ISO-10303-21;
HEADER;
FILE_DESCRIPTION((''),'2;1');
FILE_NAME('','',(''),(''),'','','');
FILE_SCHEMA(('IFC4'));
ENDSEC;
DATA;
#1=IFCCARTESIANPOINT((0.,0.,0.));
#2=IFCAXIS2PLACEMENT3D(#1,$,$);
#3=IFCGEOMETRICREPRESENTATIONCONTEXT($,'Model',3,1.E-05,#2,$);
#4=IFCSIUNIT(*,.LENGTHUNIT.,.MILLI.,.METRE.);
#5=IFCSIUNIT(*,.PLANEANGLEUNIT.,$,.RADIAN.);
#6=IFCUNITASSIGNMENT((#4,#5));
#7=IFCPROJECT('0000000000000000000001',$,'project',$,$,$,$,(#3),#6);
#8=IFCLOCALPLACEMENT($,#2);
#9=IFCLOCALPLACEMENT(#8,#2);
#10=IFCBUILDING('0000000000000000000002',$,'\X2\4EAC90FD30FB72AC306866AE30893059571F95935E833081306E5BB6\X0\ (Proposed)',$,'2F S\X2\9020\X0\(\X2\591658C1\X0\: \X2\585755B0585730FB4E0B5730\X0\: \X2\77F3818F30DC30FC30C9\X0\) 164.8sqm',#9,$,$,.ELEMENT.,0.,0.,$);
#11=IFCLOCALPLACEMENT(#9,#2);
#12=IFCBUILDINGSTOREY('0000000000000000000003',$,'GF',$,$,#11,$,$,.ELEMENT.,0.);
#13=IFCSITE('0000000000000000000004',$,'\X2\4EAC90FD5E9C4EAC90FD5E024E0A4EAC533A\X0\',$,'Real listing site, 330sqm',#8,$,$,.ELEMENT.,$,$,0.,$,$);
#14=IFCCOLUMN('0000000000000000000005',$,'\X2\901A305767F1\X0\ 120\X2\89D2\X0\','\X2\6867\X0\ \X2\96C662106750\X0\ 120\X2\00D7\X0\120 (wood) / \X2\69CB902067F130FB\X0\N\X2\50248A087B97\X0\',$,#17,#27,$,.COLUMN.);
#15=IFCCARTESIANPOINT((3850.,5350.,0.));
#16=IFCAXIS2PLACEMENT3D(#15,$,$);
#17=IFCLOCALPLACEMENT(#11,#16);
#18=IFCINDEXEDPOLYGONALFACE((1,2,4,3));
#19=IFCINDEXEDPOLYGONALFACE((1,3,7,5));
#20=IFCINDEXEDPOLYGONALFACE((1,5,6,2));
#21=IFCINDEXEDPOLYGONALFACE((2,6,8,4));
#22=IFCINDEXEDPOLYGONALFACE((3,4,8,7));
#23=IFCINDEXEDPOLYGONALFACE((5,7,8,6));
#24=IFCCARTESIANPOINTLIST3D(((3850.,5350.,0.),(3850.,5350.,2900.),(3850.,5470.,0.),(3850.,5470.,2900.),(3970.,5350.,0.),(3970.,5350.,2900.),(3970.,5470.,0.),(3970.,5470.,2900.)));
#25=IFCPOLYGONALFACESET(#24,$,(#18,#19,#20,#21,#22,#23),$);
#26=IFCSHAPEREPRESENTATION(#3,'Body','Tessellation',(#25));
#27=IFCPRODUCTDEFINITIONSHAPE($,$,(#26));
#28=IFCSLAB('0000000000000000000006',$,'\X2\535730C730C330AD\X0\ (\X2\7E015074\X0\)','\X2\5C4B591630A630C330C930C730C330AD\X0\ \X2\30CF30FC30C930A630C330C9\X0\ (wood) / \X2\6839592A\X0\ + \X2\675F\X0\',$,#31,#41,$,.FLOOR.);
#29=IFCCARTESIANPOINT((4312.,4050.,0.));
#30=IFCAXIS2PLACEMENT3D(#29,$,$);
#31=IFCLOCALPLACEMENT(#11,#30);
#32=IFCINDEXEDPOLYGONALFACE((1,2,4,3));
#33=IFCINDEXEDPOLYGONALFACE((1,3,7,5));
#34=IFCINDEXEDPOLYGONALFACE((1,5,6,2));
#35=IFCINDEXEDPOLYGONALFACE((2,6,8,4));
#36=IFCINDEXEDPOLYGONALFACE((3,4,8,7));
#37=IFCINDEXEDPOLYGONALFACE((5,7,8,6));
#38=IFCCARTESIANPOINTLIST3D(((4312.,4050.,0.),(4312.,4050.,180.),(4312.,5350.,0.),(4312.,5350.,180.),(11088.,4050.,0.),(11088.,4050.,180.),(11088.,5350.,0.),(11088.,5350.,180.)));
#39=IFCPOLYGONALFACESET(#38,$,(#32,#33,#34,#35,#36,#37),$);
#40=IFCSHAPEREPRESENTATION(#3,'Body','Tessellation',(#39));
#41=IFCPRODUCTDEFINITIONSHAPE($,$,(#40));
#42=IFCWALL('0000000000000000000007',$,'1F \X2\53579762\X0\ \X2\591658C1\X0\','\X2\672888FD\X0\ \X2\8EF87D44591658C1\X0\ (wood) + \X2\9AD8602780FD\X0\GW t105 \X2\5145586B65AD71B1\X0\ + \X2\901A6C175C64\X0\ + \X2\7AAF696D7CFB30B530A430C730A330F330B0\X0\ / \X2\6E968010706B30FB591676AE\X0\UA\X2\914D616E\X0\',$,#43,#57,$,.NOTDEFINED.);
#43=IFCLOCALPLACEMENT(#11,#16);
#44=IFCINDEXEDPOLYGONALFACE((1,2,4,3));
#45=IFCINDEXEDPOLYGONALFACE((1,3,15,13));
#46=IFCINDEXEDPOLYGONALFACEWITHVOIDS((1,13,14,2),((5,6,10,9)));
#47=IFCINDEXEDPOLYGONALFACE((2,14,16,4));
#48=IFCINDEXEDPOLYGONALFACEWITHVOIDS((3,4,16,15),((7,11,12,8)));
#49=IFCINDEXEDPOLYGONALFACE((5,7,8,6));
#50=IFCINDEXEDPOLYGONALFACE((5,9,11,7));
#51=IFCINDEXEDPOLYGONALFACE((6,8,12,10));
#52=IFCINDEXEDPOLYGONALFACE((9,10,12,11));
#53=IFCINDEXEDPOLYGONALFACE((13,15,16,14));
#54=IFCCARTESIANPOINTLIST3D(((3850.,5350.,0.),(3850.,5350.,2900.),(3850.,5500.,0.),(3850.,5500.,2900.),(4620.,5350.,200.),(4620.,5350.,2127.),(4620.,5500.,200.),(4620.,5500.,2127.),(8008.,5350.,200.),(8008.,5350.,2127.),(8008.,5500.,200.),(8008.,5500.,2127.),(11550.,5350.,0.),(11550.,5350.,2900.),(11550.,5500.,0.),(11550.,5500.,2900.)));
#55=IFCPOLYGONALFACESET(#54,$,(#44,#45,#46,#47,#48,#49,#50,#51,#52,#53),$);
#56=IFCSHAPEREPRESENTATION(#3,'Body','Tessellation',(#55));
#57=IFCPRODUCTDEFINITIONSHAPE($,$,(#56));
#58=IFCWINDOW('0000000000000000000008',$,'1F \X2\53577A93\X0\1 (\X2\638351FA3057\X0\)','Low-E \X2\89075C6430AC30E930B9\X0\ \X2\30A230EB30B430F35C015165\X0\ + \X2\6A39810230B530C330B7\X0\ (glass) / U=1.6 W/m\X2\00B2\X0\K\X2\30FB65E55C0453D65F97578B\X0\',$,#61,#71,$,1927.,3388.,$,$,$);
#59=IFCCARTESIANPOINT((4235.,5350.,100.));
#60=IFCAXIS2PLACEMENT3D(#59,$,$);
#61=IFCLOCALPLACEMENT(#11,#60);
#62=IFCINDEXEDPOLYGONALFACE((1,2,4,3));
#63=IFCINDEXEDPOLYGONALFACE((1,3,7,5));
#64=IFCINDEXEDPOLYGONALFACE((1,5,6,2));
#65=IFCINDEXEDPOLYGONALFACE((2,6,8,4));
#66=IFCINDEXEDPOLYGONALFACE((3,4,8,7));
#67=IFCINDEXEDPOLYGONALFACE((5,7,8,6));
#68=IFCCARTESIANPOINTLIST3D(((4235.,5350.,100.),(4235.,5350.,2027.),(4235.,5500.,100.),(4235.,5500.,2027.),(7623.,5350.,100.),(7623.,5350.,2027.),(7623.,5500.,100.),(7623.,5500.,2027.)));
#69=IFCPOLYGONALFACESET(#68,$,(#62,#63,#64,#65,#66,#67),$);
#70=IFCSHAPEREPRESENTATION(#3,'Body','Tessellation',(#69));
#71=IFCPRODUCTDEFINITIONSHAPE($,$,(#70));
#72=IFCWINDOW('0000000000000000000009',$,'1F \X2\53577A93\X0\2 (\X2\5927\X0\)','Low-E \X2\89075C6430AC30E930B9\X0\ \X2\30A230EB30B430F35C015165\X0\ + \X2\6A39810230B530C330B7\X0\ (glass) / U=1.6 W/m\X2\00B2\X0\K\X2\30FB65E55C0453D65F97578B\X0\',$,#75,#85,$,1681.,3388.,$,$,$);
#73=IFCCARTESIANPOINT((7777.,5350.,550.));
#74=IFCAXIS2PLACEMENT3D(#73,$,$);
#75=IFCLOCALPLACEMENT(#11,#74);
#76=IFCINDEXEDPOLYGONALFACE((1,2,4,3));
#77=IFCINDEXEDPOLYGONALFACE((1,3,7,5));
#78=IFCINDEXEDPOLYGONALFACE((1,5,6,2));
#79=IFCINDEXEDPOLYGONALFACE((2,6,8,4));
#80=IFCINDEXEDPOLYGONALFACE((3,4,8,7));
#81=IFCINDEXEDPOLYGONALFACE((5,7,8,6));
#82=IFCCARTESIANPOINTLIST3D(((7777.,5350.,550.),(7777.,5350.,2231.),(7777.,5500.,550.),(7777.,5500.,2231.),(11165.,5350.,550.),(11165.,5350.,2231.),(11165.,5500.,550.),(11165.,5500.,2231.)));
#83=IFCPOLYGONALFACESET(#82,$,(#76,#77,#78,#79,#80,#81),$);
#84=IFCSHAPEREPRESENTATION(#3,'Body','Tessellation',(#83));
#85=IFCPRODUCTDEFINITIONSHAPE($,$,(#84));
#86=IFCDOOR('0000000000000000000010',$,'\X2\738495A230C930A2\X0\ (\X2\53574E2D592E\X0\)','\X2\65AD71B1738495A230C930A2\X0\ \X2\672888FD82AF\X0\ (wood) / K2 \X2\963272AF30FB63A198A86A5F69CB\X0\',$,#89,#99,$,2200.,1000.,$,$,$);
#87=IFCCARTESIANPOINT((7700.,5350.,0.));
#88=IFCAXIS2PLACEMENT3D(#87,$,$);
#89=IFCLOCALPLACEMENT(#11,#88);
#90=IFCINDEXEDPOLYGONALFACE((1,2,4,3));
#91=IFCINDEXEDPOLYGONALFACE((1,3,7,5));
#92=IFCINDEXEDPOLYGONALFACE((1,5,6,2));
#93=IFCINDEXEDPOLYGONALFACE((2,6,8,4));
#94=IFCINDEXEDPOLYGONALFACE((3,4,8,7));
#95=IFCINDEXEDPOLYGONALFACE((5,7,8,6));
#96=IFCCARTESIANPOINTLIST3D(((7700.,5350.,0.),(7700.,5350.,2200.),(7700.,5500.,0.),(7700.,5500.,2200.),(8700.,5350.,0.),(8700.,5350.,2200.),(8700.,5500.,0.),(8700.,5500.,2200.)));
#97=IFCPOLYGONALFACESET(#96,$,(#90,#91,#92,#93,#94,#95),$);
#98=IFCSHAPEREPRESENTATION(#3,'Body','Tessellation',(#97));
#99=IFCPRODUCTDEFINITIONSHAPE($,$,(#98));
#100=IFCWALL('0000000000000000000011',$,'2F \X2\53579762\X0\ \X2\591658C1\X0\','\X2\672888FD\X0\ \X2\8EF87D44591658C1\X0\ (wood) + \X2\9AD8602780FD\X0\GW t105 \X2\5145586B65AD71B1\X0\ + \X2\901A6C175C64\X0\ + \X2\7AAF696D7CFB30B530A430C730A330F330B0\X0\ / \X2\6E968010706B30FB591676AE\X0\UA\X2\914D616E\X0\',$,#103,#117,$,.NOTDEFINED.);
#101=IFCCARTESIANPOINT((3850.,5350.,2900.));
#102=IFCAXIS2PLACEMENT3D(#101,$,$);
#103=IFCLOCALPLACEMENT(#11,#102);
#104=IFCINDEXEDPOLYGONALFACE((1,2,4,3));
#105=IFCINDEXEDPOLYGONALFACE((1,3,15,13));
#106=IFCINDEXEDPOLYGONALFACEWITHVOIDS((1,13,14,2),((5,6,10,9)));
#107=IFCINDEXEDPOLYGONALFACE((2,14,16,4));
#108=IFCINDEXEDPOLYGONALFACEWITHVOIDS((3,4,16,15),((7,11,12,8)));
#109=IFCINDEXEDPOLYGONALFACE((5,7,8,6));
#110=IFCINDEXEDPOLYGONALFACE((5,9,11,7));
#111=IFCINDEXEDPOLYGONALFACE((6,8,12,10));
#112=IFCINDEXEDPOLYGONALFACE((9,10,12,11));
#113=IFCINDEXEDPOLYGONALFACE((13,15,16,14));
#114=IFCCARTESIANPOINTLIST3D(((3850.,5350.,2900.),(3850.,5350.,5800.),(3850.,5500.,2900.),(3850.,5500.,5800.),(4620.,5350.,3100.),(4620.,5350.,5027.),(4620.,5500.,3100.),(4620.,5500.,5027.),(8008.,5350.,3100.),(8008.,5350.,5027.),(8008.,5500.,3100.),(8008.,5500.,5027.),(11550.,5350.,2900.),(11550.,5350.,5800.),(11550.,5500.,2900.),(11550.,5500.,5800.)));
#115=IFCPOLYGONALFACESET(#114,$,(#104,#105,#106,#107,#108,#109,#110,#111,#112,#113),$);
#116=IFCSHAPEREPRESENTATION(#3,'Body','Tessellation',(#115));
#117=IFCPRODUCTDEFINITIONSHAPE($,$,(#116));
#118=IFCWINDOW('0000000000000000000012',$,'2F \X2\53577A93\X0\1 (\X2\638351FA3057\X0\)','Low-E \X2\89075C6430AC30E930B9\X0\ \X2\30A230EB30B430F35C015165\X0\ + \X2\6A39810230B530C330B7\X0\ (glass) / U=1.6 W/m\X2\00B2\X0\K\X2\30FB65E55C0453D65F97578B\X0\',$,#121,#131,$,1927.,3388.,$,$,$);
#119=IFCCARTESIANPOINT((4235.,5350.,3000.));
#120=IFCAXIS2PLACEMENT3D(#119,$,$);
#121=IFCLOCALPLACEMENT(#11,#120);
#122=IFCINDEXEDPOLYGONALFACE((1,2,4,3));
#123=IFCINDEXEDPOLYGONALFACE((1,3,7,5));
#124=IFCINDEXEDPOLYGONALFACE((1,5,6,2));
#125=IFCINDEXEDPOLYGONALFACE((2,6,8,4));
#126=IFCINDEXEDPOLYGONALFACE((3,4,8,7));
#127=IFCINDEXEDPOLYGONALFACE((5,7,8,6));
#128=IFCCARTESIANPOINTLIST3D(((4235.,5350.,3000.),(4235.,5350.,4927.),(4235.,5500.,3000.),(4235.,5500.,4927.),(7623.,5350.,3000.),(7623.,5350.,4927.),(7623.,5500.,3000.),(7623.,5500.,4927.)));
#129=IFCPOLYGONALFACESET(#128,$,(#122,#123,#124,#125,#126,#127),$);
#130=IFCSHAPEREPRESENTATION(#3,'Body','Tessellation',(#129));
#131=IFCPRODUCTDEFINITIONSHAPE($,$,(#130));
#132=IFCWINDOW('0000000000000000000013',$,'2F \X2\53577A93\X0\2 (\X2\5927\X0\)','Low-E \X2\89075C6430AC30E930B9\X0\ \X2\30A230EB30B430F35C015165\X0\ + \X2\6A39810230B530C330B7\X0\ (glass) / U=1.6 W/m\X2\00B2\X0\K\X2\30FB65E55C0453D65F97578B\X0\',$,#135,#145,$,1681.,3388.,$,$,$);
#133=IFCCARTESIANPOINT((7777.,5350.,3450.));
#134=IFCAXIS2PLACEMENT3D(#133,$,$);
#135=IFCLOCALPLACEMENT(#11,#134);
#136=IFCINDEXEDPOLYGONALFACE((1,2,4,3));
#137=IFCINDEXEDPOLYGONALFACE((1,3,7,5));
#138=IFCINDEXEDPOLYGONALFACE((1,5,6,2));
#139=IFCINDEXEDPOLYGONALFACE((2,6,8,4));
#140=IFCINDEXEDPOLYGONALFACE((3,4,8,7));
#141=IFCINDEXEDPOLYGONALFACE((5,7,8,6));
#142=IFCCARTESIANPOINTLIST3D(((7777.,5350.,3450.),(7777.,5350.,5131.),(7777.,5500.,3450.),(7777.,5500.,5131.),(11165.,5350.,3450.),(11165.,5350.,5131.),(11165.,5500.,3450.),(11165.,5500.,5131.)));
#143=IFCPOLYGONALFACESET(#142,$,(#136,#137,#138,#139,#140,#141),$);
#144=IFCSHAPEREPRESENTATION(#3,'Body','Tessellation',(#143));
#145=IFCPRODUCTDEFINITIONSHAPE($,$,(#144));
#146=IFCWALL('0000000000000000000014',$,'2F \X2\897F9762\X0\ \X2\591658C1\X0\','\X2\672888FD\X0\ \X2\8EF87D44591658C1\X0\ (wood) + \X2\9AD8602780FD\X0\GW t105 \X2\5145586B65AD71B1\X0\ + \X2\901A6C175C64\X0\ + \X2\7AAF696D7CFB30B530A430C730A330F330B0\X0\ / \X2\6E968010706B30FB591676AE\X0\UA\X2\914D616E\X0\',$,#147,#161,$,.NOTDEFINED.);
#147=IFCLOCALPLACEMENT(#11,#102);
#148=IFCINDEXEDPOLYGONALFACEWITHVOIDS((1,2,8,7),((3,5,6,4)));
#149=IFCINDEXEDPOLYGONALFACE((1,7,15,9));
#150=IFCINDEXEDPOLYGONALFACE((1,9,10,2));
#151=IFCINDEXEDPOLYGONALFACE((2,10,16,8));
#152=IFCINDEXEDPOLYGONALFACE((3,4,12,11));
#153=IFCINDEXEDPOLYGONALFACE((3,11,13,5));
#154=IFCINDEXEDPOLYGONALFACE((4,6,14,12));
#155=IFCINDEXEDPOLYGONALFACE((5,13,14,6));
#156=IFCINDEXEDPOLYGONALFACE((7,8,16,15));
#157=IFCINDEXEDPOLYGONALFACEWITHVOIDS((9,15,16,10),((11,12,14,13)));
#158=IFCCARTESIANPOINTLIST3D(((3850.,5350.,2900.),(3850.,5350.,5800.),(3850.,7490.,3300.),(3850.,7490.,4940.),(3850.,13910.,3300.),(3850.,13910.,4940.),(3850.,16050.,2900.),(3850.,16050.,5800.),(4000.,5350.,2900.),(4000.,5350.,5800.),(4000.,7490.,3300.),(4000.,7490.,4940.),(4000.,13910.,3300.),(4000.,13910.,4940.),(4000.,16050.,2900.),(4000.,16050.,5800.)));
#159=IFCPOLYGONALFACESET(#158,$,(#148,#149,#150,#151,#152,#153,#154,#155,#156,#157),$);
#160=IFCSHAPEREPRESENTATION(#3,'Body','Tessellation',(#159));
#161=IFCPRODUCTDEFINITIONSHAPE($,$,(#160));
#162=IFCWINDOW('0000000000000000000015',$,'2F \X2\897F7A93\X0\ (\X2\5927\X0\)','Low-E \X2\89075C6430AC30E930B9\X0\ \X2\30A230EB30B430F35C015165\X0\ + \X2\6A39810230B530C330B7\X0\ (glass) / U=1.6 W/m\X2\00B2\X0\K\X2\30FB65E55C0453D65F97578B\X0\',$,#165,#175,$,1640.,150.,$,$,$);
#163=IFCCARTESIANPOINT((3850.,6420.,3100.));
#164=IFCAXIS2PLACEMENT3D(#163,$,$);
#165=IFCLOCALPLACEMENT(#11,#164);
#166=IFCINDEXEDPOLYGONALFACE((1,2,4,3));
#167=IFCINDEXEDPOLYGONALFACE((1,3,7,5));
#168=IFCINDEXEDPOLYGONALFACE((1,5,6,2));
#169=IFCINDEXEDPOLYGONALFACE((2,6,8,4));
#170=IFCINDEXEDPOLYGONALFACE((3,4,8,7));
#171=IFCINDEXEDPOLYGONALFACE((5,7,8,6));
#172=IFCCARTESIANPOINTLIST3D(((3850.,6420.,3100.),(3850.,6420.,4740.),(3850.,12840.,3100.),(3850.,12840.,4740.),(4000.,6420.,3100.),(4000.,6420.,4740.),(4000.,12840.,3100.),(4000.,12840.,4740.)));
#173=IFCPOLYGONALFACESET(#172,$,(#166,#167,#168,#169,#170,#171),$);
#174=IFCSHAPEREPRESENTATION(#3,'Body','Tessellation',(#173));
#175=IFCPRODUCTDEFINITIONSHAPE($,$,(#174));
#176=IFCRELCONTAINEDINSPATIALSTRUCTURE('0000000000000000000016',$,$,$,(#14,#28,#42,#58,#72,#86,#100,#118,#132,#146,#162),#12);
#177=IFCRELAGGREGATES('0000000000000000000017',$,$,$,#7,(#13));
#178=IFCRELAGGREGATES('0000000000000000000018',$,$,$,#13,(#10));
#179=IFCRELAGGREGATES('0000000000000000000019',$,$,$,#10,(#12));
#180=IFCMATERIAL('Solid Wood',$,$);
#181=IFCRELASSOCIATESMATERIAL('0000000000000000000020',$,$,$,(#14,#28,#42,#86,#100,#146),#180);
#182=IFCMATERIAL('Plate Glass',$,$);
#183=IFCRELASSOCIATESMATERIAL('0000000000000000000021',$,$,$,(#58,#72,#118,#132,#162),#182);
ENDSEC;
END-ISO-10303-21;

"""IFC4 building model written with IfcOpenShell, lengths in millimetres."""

from ifc_helpers import new_model, si_unit, frame, frame_2d, origin, place, context, project, spatial, rectangle, extrude, material, element, fill, save


model = new_model("IFC4")

# Units and contexts
model_context = context("Model", 3, precision=1e-05, world=origin())
ifc_project = project(units=[si_unit("LENGTHUNIT", "METRE", prefix="MILLI"), si_unit("PLANEANGLEUNIT", "RADIAN")], contexts=[model_context])

# Site, building, storey
site_placement = place(None, origin())
site = spatial("IfcSite", under=ifc_project, at=site_placement, Name="京都府京都市上京区", ObjectType="Real listing site, 330sqm", CompositionType="ELEMENT", RefElevation=0.0)
building_placement = place(site_placement, origin())
building = spatial("IfcBuilding", under=site, at=building_placement, Name="京都・犬と暮らす土間広めの家 (Proposed)", ObjectType="2F S造(外壁: 塗喰塗・下地: 石膏ボード) 164.8sqm", CompositionType="ELEMENT", ElevationOfRefHeight=0.0, ElevationOfTerrain=0.0)
storey_placement = place(building_placement, origin())
storey = spatial("IfcBuildingStorey", under=building, at=storey_placement, Name="GF", CompositionType="ELEMENT", Elevation=0.0)

# Column
ifc_material_1 = material(Name="Solid Wood")
column_placement = place(storey_placement, frame((3850.0, 5350.0, 0.0)))
element("IfcColumn", 1, at=column_placement, inside=storey, material=ifc_material_1, Name="通し柱 120角", Description="桧 集成材 120×120 (wood) / 構造柱・N値計算", PredefinedType="COLUMN", context=model_context, shape_type="SweptSolid", body=[
    extrude(rectangle(XDim=120.0, YDim=120.0, at=frame_2d((60.0, 60.0))), frame((3850.0, 5350.0, 0.0)), (0.0, 0.0, 1.0), 2900.0),
])

# Slab
slab_1_placement = place(storey_placement, frame((4312.0, 4050.0, 0.0)))
element("IfcSlab", 2, at=slab_1_placement, inside=storey, material=ifc_material_1, Name="南デッキ (縁側)", Description="屋外ウッドデッキ ハードウッド (wood) / 根太 + 束", PredefinedType="FLOOR", context=model_context, shape_type="SweptSolid", body=[
    extrude(rectangle(XDim=6776.0, YDim=1300.0, at=frame_2d((3388.0, 650.0))), frame((4312.0, 4050.0, 0.0)), (0.0, 0.0, 1.0), 180.0),
])

# Wall, openings, windows, door
wall_1_placement = place(storey_placement, frame((3850.0, 5350.0, 0.0)))
wall_1 = element("IfcWall", 3, at=wall_1_placement, inside=storey, material=ifc_material_1, Name="1F 南面 外壁", Description="木製 軸組外壁 (wood) + 高性能GW t105 充填断熱 + 通気層 + 窯業系サイディング / 準耐火・外皮UA配慮", PredefinedType="NOTDEFINED", context=model_context, shape_type="SweptSolid", body=[
    extrude(rectangle(XDim=7700.0, YDim=150.0, at=frame_2d((3850.0, 75.0))), frame((3850.0, 5350.0, 0.0)), (0.0, 0.0, 1.0), 2900.0),
])
opening_1_placement = place(storey_placement, frame((4235.0, 5350.0, 100.0)))
opening_1 = element("IfcOpeningElement", 4, at=opening_1_placement, cuts=wall_1, PredefinedType="NOTDEFINED", context=model_context, shape_type="SweptSolid", body=[
    extrude(rectangle(XDim=3388.0, YDim=150.0, at=frame_2d((1694.0, 75.0))), frame((4235.0, 5350.0, 100.0)), (0.0, 0.0, 1.0), 1927.0),
])
opening_2_placement = place(storey_placement, frame((7777.0, 5350.0, 550.0)))
opening_2 = element("IfcOpeningElement", 5, at=opening_2_placement, cuts=wall_1, PredefinedType="NOTDEFINED", context=model_context, shape_type="SweptSolid", body=[
    extrude(rectangle(XDim=3388.0, YDim=150.0, at=frame_2d((1694.0, 75.0))), frame((7777.0, 5350.0, 550.0)), (0.0, 0.0, 1.0), 1681.0),
])
opening_3_placement = place(storey_placement, frame((7700.0, 5350.0, 0.0)))
opening_3 = element("IfcOpeningElement", 6, at=opening_3_placement, cuts=wall_1, PredefinedType="NOTDEFINED", context=model_context, shape_type="SweptSolid", body=[
    extrude(rectangle(XDim=1000.0, YDim=150.0, at=frame_2d((500.0, 75.0))), frame((7700.0, 5350.0, 0.0)), (0.0, 0.0, 1.0), 2200.0),
])
ifc_material_2 = material(Name="Plate Glass")
window_1_placement = place(storey_placement, frame((4235.0, 5350.0, 100.0)))
window_1 = element("IfcWindow", 7, at=window_1_placement, inside=storey, material=ifc_material_2, Name="1F 南窓1 (掃出し)", Description="Low-E 複層ガラス アルゴン封入 + 樹脂サッシ (glass) / U=1.6 W/m²K・日射取得型", OverallHeight=1927.0, OverallWidth=3388.0, context=model_context, shape_type="SweptSolid", body=[
    extrude(rectangle(XDim=3388.0, YDim=150.0, at=frame_2d((1694.0, 75.0))), frame((4235.0, 5350.0, 100.0)), (0.0, 0.0, 1.0), 1927.0),
])
fill(opening_1, window_1)
window_2_placement = place(storey_placement, frame((7777.0, 5350.0, 550.0)))
window_2 = element("IfcWindow", 8, at=window_2_placement, inside=storey, material=ifc_material_2, Name="1F 南窓2 (大)", Description="Low-E 複層ガラス アルゴン封入 + 樹脂サッシ (glass) / U=1.6 W/m²K・日射取得型", OverallHeight=1681.0, OverallWidth=3388.0, context=model_context, shape_type="SweptSolid", body=[
    extrude(rectangle(XDim=3388.0, YDim=150.0, at=frame_2d((1694.0, 75.0))), frame((7777.0, 5350.0, 550.0)), (0.0, 0.0, 1.0), 1681.0),
])
fill(opening_2, window_2)
door_placement = place(storey_placement, frame((7700.0, 5350.0, 0.0)))
door = element("IfcDoor", 9, at=door_placement, inside=storey, material=ifc_material_1, Name="玄関ドア (南中央)", Description="断熱玄関ドア 木製芯 (wood) / K2 防犯・採風機構", OverallHeight=2200.0, OverallWidth=1000.0, context=model_context, shape_type="SweptSolid", body=[
    extrude(rectangle(XDim=1000.0, YDim=150.0, at=frame_2d((500.0, 75.0))), frame((7700.0, 5350.0, 0.0)), (0.0, 0.0, 1.0), 2200.0),
])
fill(opening_3, door)

# Wall, openings, windows
wall_2_placement = place(storey_placement, frame((3850.0, 5350.0, 2900.0)))
wall_2 = element("IfcWall", 10, at=wall_2_placement, inside=storey, material=ifc_material_1, Name="2F 南面 外壁", Description="木製 軸組外壁 (wood) + 高性能GW t105 充填断熱 + 通気層 + 窯業系サイディング / 準耐火・外皮UA配慮", PredefinedType="NOTDEFINED", context=model_context, shape_type="SweptSolid", body=[
    extrude(rectangle(XDim=7700.0, YDim=150.0, at=frame_2d((3850.0, 75.0))), frame((3850.0, 5350.0, 2900.0)), (0.0, 0.0, 1.0), 2900.0),
])
opening_4_placement = place(storey_placement, frame((4235.0, 5350.0, 3000.0)))
opening_4 = element("IfcOpeningElement", 11, at=opening_4_placement, cuts=wall_2, PredefinedType="NOTDEFINED", context=model_context, shape_type="SweptSolid", body=[
    extrude(rectangle(XDim=3388.0, YDim=150.0, at=frame_2d((1694.0, 75.0))), frame((4235.0, 5350.0, 3000.0)), (0.0, 0.0, 1.0), 1927.0),
])
opening_5_placement = place(storey_placement, frame((7777.0, 5350.0, 3450.0)))
opening_5 = element("IfcOpeningElement", 12, at=opening_5_placement, cuts=wall_2, PredefinedType="NOTDEFINED", context=model_context, shape_type="SweptSolid", body=[
    extrude(rectangle(XDim=3388.0, YDim=150.0, at=frame_2d((1694.0, 75.0))), frame((7777.0, 5350.0, 3450.0)), (0.0, 0.0, 1.0), 1681.0),
])
window_3_placement = place(storey_placement, frame((4235.0, 5350.0, 3000.0)))
window_3 = element("IfcWindow", 13, at=window_3_placement, inside=storey, material=ifc_material_2, Name="2F 南窓1 (掃出し)", Description="Low-E 複層ガラス アルゴン封入 + 樹脂サッシ (glass) / U=1.6 W/m²K・日射取得型", OverallHeight=1927.0, OverallWidth=3388.0, context=model_context, shape_type="SweptSolid", body=[
    extrude(rectangle(XDim=3388.0, YDim=150.0, at=frame_2d((1694.0, 75.0))), frame((4235.0, 5350.0, 3000.0)), (0.0, 0.0, 1.0), 1927.0),
])
fill(opening_4, window_3)
window_4_placement = place(storey_placement, frame((7777.0, 5350.0, 3450.0)))
window_4 = element("IfcWindow", 14, at=window_4_placement, inside=storey, material=ifc_material_2, Name="2F 南窓2 (大)", Description="Low-E 複層ガラス アルゴン封入 + 樹脂サッシ (glass) / U=1.6 W/m²K・日射取得型", OverallHeight=1681.0, OverallWidth=3388.0, context=model_context, shape_type="SweptSolid", body=[
    extrude(rectangle(XDim=3388.0, YDim=150.0, at=frame_2d((1694.0, 75.0))), frame((7777.0, 5350.0, 3450.0)), (0.0, 0.0, 1.0), 1681.0),
])
fill(opening_5, window_4)

# Wall, opening, window
wall_3_placement = place(storey_placement, frame((3850.0, 5350.0, 2900.0)))
wall_3 = element("IfcWall", 15, at=wall_3_placement, inside=storey, material=ifc_material_1, Name="2F 西面 外壁", Description="木製 軸組外壁 (wood) + 高性能GW t105 充填断熱 + 通気層 + 窯業系サイディング / 準耐火・外皮UA配慮", PredefinedType="NOTDEFINED", context=model_context, shape_type="SweptSolid", body=[
    extrude(rectangle(XDim=150.0, YDim=10700.0, at=frame_2d((75.0, 5350.0))), frame((3850.0, 5350.0, 2900.0)), (0.0, 0.0, 1.0), 2900.0),
])
opening_6_placement = place(storey_placement, frame((3850.0, 6420.0, 3100.0)))
opening_6 = element("IfcOpeningElement", 16, at=opening_6_placement, cuts=wall_3, PredefinedType="NOTDEFINED", context=model_context, shape_type="SweptSolid", body=[
    extrude(rectangle(XDim=150.0, YDim=6420.0, at=frame_2d((75.0, 3210.0))), frame((3850.0, 6420.0, 3100.0)), (0.0, 0.0, 1.0), 1640.0),
])
window_5_placement = place(storey_placement, frame((3850.0, 6420.0, 3100.0)))
window_5 = element("IfcWindow", 17, at=window_5_placement, inside=storey, material=ifc_material_2, Name="2F 西窓 (大)", Description="Low-E 複層ガラス アルゴン封入 + 樹脂サッシ (glass) / U=1.6 W/m²K・日射取得型", OverallHeight=1640.0, OverallWidth=150.0, context=model_context, shape_type="SweptSolid", body=[
    extrude(rectangle(XDim=150.0, YDim=6420.0, at=frame_2d((75.0, 3210.0))), frame((3850.0, 6420.0, 3100.0)), (0.0, 0.0, 1.0), 1640.0),
])
fill(opening_6, window_5)

save(model, "model.ifc")
